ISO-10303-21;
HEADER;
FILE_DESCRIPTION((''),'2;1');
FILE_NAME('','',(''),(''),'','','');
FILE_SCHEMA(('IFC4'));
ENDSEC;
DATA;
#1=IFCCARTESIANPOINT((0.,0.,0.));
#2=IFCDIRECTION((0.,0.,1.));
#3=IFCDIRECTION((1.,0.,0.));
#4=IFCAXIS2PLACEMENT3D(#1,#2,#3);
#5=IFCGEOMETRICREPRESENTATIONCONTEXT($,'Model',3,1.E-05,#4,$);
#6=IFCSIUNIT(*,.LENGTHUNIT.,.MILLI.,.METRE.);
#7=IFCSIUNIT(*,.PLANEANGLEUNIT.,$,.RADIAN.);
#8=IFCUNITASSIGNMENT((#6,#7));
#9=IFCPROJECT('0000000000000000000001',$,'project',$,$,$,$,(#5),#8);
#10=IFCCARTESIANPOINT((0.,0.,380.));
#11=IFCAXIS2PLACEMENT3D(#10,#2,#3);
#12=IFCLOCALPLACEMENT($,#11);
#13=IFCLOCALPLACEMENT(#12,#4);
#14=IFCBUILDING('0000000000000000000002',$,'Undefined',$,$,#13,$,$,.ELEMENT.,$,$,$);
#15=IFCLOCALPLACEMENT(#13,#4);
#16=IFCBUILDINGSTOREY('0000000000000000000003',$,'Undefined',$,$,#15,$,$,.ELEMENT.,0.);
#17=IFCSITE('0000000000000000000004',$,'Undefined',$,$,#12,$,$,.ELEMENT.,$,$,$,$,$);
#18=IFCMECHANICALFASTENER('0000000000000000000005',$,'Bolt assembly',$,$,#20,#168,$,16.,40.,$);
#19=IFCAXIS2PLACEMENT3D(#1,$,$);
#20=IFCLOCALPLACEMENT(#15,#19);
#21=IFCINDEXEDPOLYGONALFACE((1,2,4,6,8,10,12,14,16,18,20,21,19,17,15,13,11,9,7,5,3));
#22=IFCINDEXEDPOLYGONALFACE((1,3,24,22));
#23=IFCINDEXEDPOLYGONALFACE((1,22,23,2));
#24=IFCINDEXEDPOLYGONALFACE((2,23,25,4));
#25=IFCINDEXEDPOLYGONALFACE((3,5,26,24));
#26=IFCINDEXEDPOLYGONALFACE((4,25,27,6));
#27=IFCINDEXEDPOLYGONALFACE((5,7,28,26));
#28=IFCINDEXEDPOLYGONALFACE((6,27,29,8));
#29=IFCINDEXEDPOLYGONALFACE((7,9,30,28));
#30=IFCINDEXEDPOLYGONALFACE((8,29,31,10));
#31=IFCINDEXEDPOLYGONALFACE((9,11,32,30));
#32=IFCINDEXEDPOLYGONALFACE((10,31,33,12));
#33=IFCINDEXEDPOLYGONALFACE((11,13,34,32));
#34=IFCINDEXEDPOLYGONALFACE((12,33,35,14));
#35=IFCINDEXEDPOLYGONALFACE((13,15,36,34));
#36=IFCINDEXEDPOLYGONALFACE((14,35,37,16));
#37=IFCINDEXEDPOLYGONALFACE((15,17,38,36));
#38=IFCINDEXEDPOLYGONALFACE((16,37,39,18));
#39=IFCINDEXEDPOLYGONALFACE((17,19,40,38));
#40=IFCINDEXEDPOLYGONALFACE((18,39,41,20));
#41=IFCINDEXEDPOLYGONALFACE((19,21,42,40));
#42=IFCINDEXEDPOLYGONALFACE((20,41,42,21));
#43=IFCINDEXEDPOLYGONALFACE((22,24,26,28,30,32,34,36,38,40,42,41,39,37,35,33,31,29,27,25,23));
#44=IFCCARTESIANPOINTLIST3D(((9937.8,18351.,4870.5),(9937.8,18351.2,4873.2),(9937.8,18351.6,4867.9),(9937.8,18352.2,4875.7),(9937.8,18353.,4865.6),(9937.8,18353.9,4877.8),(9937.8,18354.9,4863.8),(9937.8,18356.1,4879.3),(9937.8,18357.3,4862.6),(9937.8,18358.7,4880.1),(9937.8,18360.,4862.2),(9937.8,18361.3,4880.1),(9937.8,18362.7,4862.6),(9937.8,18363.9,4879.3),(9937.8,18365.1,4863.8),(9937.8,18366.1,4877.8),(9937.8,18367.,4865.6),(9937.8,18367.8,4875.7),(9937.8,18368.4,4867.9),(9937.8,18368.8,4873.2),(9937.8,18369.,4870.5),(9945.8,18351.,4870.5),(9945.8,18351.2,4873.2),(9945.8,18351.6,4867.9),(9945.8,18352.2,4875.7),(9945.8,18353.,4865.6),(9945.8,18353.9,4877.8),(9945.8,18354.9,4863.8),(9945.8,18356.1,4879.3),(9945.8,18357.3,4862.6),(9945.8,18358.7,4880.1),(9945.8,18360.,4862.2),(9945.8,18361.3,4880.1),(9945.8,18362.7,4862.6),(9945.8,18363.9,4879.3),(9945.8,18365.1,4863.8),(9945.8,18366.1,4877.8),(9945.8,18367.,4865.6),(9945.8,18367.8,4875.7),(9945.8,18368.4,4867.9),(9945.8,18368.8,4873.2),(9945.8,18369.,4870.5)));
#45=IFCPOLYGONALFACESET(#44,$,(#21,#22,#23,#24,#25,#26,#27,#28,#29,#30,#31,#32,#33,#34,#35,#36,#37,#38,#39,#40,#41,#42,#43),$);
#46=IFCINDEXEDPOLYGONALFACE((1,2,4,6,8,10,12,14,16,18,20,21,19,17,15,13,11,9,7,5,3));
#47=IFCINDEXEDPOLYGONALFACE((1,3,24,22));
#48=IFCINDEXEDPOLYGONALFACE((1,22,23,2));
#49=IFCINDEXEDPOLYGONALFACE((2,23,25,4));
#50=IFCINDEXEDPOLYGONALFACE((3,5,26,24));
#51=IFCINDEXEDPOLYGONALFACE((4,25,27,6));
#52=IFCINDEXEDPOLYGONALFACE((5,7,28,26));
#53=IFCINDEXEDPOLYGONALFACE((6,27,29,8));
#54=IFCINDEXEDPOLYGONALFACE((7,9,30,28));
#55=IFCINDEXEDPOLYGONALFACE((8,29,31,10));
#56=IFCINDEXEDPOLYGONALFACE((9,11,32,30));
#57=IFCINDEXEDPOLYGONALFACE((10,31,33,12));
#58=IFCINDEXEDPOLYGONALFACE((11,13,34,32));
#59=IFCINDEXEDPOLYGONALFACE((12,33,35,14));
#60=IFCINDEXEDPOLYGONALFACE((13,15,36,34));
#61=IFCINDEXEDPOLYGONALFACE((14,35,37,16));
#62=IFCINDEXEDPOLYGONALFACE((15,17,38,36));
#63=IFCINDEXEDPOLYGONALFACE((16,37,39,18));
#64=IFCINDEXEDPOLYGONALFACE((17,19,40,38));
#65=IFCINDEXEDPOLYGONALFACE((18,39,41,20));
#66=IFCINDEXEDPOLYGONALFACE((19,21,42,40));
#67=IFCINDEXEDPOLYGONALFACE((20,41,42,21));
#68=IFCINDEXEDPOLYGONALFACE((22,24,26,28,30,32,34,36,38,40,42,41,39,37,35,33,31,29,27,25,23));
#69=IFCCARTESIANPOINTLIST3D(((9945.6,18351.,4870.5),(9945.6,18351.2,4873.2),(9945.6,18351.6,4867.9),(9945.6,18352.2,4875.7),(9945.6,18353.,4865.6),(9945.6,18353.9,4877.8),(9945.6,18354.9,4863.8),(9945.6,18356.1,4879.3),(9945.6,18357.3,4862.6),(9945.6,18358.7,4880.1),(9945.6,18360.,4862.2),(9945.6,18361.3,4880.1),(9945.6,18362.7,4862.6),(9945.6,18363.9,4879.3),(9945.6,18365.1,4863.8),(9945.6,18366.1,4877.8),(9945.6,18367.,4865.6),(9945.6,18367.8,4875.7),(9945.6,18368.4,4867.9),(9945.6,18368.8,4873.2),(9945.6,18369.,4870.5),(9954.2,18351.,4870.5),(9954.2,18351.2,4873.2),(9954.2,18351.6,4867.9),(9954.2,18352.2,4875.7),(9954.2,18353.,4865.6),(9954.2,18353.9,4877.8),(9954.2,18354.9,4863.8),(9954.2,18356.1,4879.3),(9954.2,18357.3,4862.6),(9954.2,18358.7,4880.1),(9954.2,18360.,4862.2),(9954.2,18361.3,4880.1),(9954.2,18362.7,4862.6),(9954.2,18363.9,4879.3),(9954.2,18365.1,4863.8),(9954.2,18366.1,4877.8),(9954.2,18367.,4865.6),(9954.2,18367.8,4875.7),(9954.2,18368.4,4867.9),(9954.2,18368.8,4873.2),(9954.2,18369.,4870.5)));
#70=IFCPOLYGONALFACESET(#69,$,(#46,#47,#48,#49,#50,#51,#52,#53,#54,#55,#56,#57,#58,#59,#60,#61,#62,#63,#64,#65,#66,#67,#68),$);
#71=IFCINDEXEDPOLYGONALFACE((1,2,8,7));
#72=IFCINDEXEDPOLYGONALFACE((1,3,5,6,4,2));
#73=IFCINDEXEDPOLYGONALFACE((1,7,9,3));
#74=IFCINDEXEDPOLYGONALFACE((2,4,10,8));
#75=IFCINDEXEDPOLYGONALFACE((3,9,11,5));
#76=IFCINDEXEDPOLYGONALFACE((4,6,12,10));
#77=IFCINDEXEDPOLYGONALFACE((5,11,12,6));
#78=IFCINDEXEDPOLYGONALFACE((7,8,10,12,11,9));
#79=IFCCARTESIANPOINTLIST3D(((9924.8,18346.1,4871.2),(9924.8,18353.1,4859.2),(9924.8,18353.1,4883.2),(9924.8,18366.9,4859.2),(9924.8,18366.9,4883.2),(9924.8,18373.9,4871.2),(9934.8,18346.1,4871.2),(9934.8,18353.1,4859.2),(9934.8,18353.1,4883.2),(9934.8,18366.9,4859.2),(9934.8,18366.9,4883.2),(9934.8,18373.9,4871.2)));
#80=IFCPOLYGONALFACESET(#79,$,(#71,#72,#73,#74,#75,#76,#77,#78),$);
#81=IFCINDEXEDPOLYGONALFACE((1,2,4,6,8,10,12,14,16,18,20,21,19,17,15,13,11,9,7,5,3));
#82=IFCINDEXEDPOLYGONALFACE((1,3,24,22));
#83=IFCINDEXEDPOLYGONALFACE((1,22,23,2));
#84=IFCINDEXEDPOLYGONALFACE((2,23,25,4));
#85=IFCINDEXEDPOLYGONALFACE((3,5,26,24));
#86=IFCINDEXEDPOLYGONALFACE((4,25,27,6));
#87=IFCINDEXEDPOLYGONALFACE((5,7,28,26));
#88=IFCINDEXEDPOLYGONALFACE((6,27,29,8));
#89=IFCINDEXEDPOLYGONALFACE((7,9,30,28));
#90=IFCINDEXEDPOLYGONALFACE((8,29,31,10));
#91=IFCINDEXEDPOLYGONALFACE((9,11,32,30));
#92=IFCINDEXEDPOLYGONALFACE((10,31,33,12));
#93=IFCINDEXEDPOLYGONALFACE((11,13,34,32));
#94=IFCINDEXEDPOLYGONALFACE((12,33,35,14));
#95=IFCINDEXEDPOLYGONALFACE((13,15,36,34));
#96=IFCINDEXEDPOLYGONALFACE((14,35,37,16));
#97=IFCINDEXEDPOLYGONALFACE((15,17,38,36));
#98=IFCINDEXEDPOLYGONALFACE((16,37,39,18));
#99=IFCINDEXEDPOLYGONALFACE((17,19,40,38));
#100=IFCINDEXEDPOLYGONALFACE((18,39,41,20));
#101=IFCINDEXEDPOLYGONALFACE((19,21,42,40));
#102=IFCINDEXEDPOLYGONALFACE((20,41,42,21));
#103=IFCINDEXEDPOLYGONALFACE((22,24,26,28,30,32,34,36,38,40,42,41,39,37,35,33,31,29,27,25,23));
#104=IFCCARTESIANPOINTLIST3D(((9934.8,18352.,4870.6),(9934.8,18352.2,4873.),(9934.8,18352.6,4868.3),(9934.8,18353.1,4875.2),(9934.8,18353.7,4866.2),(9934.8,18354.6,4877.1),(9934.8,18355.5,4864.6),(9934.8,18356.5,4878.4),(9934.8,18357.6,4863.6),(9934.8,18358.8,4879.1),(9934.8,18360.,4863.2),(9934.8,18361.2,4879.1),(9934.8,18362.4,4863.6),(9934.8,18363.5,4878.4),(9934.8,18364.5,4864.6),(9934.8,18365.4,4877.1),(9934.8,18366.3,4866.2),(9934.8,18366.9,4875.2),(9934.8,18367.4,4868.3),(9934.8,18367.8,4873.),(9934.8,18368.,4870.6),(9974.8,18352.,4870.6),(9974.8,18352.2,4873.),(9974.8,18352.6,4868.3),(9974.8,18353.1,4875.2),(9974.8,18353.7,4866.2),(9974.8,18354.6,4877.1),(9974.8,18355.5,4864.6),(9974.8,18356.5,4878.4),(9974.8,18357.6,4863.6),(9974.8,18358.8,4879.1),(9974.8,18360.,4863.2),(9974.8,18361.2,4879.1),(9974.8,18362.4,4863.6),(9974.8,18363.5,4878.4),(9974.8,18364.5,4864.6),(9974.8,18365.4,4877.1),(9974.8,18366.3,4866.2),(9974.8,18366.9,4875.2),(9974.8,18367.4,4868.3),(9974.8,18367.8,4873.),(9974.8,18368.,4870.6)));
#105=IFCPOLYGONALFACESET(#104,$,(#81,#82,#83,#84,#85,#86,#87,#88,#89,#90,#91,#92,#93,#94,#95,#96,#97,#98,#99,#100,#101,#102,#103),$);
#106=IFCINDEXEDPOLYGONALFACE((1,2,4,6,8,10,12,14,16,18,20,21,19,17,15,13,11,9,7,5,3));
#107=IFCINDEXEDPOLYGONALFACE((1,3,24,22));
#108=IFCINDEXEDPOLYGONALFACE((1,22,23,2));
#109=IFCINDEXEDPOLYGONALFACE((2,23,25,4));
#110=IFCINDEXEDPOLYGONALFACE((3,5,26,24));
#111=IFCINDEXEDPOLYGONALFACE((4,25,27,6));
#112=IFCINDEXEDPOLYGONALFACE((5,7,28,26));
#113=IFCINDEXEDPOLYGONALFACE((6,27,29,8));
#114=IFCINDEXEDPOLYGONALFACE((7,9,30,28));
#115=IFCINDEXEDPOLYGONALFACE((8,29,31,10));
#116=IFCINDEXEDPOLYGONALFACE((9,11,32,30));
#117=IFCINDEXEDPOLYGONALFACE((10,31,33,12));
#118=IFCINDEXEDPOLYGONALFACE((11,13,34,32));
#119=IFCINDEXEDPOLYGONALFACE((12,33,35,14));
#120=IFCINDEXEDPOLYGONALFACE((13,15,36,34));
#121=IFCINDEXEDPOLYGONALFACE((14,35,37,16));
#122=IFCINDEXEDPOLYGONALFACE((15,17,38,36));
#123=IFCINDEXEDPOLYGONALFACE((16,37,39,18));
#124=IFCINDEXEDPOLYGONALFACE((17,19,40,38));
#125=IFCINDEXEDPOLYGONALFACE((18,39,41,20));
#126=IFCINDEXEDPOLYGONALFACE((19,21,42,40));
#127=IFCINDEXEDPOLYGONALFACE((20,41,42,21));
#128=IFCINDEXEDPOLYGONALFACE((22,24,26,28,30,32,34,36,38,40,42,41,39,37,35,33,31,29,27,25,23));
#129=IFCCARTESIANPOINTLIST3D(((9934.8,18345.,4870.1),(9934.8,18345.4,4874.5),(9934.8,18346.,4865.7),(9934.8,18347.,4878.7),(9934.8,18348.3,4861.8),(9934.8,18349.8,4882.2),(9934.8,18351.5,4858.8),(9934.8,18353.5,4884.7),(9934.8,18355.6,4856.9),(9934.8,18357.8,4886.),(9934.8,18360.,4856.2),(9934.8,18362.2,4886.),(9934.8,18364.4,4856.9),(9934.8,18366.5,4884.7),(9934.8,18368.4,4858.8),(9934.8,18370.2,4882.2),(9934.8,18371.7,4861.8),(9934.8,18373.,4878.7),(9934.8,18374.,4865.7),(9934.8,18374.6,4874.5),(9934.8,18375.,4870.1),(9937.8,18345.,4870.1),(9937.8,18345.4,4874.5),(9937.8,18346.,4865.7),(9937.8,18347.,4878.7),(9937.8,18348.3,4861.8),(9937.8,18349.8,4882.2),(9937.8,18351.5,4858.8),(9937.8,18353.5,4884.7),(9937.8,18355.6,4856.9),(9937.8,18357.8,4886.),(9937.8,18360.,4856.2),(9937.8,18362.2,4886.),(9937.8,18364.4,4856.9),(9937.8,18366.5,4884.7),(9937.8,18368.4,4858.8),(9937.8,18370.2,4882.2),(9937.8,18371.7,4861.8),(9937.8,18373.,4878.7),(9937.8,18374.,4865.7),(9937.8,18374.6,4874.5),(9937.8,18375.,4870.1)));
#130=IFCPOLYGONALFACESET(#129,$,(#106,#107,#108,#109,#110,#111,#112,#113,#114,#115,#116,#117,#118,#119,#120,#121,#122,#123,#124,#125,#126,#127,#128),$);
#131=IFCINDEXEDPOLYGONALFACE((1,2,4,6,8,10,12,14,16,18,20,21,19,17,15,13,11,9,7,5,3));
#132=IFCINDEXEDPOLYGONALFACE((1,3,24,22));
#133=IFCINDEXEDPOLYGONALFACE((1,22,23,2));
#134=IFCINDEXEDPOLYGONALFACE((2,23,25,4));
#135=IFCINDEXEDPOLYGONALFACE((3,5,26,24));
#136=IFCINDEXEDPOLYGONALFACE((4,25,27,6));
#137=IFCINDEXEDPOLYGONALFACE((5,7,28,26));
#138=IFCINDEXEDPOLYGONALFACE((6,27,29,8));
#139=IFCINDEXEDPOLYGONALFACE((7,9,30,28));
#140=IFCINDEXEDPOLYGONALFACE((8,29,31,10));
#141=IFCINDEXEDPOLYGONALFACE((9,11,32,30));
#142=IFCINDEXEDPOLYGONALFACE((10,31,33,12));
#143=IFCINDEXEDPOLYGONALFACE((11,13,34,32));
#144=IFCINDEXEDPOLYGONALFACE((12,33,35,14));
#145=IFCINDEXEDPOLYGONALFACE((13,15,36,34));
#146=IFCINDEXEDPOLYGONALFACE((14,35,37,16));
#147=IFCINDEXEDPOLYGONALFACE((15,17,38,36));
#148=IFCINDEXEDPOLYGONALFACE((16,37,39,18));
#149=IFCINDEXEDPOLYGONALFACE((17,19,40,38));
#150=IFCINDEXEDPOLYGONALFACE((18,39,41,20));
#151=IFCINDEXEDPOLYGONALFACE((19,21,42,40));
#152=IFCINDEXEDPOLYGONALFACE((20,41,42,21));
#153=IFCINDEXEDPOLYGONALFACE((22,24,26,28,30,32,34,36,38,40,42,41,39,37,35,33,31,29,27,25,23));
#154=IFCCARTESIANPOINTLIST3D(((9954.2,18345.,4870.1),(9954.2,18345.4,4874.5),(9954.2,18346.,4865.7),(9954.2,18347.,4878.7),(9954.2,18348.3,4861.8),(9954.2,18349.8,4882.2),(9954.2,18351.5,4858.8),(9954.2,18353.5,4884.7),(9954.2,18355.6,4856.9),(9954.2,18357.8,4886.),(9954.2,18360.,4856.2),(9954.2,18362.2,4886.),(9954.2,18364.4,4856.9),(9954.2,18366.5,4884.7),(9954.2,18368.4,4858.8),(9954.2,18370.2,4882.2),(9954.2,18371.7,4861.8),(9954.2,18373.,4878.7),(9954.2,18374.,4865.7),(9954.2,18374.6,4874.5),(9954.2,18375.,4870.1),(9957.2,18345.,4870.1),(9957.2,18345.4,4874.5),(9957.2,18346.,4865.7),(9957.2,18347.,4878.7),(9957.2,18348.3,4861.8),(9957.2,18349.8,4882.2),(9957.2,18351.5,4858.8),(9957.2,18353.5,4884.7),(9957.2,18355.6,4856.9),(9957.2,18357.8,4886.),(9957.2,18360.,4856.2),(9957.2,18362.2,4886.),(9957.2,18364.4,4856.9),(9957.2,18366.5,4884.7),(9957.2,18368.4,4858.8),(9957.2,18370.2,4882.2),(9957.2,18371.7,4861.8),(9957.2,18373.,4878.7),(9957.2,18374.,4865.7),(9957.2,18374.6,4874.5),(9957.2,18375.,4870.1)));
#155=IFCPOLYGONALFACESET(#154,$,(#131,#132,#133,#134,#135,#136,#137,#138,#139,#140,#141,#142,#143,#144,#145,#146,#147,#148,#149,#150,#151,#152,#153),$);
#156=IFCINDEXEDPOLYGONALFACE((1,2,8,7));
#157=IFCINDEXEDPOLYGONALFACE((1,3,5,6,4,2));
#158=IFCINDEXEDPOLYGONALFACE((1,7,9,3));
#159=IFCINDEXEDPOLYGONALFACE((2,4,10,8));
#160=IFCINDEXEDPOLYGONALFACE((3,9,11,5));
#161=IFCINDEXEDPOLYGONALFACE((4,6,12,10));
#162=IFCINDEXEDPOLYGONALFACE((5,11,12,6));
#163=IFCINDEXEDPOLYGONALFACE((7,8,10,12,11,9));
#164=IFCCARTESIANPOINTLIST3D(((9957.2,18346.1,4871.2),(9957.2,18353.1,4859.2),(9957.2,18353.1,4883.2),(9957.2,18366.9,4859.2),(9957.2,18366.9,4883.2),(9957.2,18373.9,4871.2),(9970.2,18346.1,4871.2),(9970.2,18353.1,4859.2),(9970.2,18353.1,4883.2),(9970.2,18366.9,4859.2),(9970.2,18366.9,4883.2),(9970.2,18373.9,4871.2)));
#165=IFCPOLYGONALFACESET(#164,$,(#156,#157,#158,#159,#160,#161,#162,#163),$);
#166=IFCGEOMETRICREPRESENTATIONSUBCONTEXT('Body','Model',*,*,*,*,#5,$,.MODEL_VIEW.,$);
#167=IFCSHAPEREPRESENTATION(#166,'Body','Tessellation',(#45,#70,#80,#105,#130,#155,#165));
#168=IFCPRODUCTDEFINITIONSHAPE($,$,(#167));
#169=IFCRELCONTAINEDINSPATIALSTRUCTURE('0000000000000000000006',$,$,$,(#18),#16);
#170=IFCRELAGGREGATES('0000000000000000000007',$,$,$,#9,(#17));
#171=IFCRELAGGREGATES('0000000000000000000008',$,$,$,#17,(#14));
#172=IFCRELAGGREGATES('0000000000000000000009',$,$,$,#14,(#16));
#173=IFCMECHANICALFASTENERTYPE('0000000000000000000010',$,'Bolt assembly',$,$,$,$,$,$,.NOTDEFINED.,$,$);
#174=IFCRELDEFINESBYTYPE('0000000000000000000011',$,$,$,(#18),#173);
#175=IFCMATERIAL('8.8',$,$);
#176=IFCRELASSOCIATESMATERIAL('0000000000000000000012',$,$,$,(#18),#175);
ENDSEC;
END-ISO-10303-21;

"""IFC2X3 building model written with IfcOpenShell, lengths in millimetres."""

from ifc_helpers import new_model, si_unit, frame, origin_with_axes, origin_2d_with_axis, place, context, subcontext, project, spatial, polyline, circle, outline, extrude, source, transform, mapped, material, type_object, element, save


model = new_model("IFC2X3")

# Units and contexts
model_context = context("Model", 3, precision=1e-05, world=origin_with_axes())
body_context = subcontext(model_context, "Body", "Model", "MODEL_VIEW")
ifc_project = project(units=[si_unit("LENGTHUNIT", "METRE", prefix="MILLI"), si_unit("PLANEANGLEUNIT", "RADIAN")], contexts=[model_context])

# Site, building, storey
site_placement = place(None, frame((0.0, 0.0, 380.0), z_axis=(0.0, 0.0, 1.0), x_axis=(1.0, 0.0, 0.0)))
site = spatial("IfcSite", under=ifc_project, at=site_placement, Name="Undefined", CompositionType="ELEMENT")
building_placement = place(site_placement, origin_with_axes())
building = spatial("IfcBuilding", under=site, at=building_placement, Name="Undefined", CompositionType="ELEMENT")
storey_placement = place(building_placement, origin_with_axes())
storey = spatial("IfcBuildingStorey", under=building, at=storey_placement, Name="Undefined", CompositionType="ELEMENT", Elevation=0.0)

# Mechanical fastener
ifc_material_1 = material(Name="8.8")
mechanical_fastener_type = type_object("IfcMechanicalFastenerType", Name="Bolt assembly")
shared_shape_1 = source(origin_with_axes(), body_context, "Body", "SweptSolid", [
    extrude(circle(Radius=9.0, at=origin_2d_with_axis()), frame((0.0, -7.9, 0.0), z_axis=(0.0, 1.0, 0.0), x_axis=(1.0, 0.0, 0.0)), (0.0, 0.0, 1.0), 8.0),
    extrude(circle(Radius=9.0, at=origin_2d_with_axis()), frame((0.0, -0.1, 0.0), z_axis=(0.0, 1.0, 0.0), x_axis=(1.0, 0.0, 0.0)), (0.0, 0.0, 1.0), 8.6),
    extrude(outline(polyline([(12.0, -6.9), (12.0, 6.9), (0.0, 13.9), (-12.0, 6.9), (-12.0, -6.9), (0.0, -13.9), (12.0, -6.9)])), frame((0.0, -21.0, 0.0), z_axis=(0.0, 1.0, 0.0), x_axis=(1.0, 0.0, 0.0)), (0.0, 0.0, 1.0), 10.0),
    extrude(circle(Radius=8.0, at=origin_2d_with_axis()), frame((0.0, -11.0, 0.0), z_axis=(0.0, 1.0, 0.0), x_axis=(1.0, 0.0, 0.0)), (0.0, 0.0, 1.0), 40.0),
    extrude(circle(Radius=15.0, at=origin_2d_with_axis()), frame((0.0, -11.0, 0.0), z_axis=(0.0, 1.0, 0.0), x_axis=(1.0, 0.0, 0.0)), (0.0, 0.0, 1.0), 3.0),
    extrude(circle(Radius=15.0, at=origin_2d_with_axis()), frame((0.0, 8.5, 0.0), z_axis=(0.0, 1.0, 0.0), x_axis=(1.0, 0.0, 0.0)), (0.0, 0.0, 1.0), 3.0),
    extrude(outline(polyline([(12.0, -6.9), (12.0, 6.9), (0.0, 13.9), (-12.0, 6.9), (-12.0, -6.9), (0.0, -13.9), (12.0, -6.9)])), frame((0.0, 11.5, 0.0), z_axis=(0.0, 1.0, 0.0), x_axis=(1.0, 0.0, 0.0)), (0.0, 0.0, 1.0), 13.0),
])
for number, where, z_axis, x_axis, name in (
    (1, (9945.8, 18397.5, 4951.2), (0.0, -1.0, 0.0), (0.0, 0.0, -1.0), "Bolt assembly"),
):
    element("IfcMechanicalFastener", number, at=place(storey_placement, frame(where, z_axis=z_axis, x_axis=x_axis)), inside=storey, type_object=mechanical_fastener_type, material=ifc_material_1, Name=name, NominalDiameter=16.0, NominalLength=40.0, context=body_context, shape_type="MappedRepresentation", body=[
        mapped(shared_shape_1, transform((80.0, 0.0, 37.5))),
    ])

save(model, "model.ifc")
